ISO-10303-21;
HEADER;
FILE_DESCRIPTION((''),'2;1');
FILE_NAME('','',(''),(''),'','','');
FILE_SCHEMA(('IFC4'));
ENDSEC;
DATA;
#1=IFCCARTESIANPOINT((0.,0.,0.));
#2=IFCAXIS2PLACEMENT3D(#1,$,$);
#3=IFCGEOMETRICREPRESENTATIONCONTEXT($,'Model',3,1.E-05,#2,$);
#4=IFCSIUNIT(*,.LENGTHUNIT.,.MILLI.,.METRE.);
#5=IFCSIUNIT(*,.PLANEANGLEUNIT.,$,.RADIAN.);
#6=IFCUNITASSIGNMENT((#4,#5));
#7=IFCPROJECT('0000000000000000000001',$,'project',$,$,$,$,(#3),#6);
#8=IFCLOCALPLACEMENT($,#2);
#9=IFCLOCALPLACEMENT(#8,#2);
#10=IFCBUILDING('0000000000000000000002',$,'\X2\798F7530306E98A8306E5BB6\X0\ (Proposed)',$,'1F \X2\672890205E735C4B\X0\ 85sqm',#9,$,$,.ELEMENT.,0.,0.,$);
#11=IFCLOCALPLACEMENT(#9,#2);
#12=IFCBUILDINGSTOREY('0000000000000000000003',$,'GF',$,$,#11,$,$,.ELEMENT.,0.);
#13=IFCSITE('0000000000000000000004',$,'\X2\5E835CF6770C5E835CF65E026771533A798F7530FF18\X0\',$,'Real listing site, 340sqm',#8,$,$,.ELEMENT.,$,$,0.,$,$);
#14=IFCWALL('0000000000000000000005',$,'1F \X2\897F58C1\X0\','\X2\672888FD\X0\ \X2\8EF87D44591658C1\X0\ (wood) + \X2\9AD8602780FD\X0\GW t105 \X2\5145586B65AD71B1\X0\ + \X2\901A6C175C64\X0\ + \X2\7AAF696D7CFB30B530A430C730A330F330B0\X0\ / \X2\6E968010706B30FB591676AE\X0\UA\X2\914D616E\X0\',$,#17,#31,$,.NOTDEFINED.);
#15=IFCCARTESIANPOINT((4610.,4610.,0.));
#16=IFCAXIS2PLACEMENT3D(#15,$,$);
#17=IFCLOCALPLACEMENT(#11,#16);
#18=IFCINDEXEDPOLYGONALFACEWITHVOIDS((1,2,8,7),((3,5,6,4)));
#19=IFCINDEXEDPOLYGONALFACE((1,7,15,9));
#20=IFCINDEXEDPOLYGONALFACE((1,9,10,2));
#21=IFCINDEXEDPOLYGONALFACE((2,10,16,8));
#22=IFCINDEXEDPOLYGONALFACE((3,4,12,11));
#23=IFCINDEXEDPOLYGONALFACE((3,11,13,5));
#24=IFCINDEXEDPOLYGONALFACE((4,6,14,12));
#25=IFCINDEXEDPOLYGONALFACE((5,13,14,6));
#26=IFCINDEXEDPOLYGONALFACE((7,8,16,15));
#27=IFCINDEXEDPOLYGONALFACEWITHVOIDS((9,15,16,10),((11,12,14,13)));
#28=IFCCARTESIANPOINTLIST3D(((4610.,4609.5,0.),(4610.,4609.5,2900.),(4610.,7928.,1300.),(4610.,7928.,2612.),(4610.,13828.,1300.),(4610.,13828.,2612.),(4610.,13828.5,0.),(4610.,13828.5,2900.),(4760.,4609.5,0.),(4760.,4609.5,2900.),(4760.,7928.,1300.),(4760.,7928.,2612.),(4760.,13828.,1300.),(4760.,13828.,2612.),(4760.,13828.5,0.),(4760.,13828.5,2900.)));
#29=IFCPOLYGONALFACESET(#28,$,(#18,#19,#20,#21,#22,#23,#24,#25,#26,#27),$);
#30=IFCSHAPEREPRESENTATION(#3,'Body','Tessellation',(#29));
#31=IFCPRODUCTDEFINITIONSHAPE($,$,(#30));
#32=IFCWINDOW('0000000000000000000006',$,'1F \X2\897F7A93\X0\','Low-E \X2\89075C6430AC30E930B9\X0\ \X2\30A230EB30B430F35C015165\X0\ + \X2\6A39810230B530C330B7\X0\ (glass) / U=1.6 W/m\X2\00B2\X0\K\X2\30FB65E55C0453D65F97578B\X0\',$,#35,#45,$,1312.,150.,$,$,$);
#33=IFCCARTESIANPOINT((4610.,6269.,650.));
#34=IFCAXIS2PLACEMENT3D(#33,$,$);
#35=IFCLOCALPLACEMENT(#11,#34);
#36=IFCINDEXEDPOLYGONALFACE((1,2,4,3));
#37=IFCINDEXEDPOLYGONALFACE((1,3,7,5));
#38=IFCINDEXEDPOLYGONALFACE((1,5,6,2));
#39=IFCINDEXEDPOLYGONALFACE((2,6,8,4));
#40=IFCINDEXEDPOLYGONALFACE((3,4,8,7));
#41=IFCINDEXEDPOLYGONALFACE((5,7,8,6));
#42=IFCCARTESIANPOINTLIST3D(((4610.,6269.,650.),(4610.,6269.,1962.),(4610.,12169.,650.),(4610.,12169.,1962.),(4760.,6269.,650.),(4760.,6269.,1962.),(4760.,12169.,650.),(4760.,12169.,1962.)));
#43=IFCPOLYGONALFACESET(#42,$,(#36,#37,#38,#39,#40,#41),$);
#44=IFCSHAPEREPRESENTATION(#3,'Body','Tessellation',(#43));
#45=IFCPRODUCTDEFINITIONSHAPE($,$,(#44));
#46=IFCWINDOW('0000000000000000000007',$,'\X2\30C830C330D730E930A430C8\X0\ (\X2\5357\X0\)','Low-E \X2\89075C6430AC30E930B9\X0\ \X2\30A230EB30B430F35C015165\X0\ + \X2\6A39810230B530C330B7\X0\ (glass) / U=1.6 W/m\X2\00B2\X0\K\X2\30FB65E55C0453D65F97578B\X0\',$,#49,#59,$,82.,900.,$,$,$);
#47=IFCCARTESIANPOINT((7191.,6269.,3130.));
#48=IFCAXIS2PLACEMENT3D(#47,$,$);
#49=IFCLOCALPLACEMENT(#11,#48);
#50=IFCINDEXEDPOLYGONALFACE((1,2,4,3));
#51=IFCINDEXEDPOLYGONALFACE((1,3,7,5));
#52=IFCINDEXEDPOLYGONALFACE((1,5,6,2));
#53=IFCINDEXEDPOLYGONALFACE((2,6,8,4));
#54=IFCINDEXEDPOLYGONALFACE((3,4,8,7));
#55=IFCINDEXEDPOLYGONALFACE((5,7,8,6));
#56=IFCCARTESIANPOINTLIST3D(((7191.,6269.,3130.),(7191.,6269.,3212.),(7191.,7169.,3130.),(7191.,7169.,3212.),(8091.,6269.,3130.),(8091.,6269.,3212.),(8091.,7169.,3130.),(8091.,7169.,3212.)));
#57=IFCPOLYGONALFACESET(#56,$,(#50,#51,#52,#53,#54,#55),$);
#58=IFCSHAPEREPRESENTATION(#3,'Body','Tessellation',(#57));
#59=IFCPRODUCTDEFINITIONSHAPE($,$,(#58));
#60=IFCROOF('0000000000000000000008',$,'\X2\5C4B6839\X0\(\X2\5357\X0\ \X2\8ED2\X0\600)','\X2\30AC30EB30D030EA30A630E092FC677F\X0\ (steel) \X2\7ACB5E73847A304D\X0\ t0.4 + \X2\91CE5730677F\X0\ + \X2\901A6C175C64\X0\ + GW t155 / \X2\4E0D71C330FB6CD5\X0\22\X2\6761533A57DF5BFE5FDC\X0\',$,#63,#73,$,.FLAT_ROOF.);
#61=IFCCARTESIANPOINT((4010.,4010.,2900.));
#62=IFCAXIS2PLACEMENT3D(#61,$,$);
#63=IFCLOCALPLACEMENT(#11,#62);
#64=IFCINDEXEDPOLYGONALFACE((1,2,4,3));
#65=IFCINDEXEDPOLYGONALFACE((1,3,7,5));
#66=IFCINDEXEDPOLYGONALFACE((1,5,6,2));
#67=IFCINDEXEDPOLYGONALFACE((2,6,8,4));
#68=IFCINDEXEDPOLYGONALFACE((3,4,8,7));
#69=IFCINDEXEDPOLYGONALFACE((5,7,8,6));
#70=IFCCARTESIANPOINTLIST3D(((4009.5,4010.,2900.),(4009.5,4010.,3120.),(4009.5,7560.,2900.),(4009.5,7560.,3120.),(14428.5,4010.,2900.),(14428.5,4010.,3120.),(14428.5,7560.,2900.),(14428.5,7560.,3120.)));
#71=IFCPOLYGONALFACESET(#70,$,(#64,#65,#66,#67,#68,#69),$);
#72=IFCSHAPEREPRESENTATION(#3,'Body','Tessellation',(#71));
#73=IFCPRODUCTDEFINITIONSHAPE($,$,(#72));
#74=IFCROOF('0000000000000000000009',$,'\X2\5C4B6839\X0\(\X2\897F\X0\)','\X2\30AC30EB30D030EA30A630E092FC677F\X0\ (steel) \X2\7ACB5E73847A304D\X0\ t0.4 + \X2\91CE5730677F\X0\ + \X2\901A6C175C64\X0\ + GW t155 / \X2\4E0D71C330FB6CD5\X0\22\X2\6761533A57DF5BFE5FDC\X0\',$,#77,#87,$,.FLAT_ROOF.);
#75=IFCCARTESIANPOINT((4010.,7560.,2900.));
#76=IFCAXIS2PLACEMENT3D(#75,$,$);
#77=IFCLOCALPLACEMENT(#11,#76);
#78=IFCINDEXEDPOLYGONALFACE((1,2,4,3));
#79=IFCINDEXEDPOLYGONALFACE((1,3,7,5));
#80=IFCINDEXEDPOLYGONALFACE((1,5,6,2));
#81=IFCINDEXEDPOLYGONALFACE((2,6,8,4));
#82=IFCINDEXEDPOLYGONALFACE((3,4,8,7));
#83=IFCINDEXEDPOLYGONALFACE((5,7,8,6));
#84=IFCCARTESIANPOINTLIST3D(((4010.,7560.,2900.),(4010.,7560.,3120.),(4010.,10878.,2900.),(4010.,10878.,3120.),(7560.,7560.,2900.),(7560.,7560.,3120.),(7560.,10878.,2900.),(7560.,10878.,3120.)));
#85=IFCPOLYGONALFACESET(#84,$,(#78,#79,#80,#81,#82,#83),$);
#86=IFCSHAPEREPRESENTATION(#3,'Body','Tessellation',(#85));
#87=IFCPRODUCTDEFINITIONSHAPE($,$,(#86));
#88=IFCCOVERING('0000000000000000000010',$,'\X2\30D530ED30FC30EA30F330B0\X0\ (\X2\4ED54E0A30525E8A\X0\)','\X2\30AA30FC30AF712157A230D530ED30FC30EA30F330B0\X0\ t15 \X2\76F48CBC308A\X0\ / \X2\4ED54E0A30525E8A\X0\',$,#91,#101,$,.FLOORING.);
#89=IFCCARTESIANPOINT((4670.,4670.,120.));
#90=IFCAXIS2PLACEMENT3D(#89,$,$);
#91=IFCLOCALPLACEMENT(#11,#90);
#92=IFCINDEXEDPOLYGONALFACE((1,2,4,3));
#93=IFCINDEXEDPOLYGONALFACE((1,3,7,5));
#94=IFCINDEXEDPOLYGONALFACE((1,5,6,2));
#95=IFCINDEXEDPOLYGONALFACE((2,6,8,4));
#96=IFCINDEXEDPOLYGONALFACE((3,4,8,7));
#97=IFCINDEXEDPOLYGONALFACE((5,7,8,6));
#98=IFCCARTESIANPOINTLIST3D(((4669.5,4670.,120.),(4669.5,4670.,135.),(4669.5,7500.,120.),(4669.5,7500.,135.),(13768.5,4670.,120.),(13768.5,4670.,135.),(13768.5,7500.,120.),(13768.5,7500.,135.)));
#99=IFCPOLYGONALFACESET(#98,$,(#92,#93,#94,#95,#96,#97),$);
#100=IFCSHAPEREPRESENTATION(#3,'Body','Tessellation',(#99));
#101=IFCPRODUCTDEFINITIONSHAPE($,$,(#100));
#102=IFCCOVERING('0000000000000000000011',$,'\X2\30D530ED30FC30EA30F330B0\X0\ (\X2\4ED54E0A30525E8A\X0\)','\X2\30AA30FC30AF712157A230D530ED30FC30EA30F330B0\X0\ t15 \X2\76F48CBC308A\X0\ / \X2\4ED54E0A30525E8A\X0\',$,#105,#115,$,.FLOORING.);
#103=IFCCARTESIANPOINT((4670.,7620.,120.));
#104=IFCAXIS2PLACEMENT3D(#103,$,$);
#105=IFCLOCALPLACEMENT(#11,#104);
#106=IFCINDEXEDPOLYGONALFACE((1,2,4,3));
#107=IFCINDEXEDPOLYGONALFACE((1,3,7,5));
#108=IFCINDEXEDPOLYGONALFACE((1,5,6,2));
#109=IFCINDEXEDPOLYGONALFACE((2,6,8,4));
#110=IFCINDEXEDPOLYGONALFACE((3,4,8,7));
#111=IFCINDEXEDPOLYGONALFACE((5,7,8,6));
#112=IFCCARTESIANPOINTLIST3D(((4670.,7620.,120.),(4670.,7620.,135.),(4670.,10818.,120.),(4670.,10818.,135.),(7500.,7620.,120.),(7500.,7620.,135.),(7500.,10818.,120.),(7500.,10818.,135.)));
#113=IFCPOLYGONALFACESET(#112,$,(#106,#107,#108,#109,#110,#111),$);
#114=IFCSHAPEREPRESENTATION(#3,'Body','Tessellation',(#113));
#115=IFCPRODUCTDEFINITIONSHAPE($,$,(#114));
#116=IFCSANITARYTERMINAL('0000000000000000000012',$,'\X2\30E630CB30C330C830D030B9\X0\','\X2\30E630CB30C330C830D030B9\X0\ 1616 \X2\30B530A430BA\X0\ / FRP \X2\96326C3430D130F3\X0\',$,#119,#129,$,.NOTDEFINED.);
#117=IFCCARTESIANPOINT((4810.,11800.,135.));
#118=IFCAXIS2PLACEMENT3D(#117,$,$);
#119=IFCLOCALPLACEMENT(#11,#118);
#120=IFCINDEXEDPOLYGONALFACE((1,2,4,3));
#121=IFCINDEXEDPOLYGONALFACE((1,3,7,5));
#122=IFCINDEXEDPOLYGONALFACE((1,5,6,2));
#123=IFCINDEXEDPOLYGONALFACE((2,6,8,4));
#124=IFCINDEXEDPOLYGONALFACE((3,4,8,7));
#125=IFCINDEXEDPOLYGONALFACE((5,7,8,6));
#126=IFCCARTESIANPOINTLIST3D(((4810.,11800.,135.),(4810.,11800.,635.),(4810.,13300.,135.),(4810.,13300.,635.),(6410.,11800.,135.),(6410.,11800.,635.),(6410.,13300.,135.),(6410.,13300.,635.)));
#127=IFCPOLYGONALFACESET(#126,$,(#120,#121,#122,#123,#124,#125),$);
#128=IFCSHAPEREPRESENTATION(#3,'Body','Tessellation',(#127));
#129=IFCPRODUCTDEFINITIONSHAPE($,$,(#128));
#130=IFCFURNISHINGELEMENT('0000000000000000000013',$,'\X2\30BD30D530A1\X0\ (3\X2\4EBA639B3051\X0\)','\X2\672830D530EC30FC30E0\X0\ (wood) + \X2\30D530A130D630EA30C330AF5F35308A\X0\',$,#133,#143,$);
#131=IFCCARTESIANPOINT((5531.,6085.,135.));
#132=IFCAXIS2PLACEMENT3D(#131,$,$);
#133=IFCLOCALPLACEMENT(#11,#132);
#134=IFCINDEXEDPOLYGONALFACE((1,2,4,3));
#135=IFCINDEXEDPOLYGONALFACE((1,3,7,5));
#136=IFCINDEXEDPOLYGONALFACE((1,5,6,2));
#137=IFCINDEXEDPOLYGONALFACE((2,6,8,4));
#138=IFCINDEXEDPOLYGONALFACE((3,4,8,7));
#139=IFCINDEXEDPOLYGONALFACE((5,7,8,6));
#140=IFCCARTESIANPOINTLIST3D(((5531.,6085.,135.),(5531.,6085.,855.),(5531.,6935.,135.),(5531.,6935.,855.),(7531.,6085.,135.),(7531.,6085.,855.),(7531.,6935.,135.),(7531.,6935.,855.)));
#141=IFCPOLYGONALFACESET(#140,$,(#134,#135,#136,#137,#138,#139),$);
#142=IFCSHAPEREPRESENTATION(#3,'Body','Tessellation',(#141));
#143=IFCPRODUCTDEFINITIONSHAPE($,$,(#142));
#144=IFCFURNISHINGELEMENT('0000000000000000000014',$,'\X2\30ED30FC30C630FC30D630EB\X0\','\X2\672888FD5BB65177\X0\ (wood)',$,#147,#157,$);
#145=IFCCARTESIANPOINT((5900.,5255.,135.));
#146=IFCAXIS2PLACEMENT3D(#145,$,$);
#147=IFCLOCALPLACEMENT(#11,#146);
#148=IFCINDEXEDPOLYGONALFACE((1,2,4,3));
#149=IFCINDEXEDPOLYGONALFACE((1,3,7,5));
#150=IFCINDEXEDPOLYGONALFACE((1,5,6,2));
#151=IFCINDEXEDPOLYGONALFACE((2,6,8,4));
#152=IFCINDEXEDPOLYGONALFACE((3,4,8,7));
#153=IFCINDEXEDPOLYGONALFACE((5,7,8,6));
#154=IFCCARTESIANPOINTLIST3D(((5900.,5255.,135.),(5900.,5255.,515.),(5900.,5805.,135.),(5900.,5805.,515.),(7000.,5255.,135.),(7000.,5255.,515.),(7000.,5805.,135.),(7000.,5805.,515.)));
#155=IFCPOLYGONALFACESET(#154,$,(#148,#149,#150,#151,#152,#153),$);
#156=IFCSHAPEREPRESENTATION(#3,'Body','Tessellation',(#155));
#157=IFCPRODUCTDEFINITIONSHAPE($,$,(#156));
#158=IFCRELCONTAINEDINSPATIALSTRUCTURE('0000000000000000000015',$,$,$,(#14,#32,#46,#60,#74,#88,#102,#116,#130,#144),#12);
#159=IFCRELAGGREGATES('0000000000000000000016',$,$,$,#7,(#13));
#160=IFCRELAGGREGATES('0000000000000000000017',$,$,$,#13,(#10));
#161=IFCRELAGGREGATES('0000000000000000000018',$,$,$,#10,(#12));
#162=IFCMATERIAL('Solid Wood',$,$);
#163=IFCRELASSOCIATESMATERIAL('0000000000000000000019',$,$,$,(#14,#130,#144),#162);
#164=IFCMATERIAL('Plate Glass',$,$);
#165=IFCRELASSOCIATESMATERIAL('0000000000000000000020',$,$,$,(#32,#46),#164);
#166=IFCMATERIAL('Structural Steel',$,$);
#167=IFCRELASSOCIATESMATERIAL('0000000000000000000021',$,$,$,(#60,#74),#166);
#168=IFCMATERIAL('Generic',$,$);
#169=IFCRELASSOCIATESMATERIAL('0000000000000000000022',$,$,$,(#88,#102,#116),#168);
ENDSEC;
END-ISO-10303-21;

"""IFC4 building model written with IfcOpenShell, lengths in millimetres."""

from ifc_helpers import new_model, si_unit, frame, frame_2d, origin, place, context, project, spatial, rectangle, extrude, material, element, fill, save


model = new_model("IFC4")

# Units and contexts
model_context = context("Model", 3, precision=1e-05, world=origin())
ifc_project = project(units=[si_unit("LENGTHUNIT", "METRE", prefix="MILLI"), si_unit("PLANEANGLEUNIT", "RADIAN")], contexts=[model_context])

# Site, building, storey
site_placement = place(None, origin())
site = spatial("IfcSite", under=ifc_project, at=site_placement, Name="広島県広島市東区福田８", ObjectType="Real listing site, 340sqm", CompositionType="ELEMENT", RefElevation=0.0)
building_placement = place(site_placement, origin())
building = spatial("IfcBuilding", under=site, at=building_placement, Name="福田の風の家 (Proposed)", ObjectType="1F 木造平屋 85sqm", CompositionType="ELEMENT", ElevationOfRefHeight=0.0, ElevationOfTerrain=0.0)
storey_placement = place(building_placement, origin())
storey = spatial("IfcBuildingStorey", under=building, at=storey_placement, Name="GF", CompositionType="ELEMENT", Elevation=0.0)

# Shared definitions
ifc_material_1 = material(Name="Solid Wood")

# Shared definitions
ifc_material_2 = material(Name="Plate Glass")

# Wall, opening, window
wall_1_placement = place(storey_placement, frame((4610.0, 4610.0, 0.0)))
wall_1 = element("IfcWall", 1, at=wall_1_placement, inside=storey, material=ifc_material_1, Name="1F 西壁", Description="木製 軸組外壁 (wood) + 高性能GW t105 充填断熱 + 通気層 + 窯業系サイディング / 準耐火・外皮UA配慮", PredefinedType="NOTDEFINED", context=model_context, shape_type="SweptSolid", body=[
    extrude(rectangle(XDim=150.0, YDim=9219.0, at=frame_2d((75.0, 4609.0))), frame((4610.0, 4610.0, 0.0)), (0.0, 0.0, 1.0), 2900.0),
])
opening_1_placement = place(storey_placement, frame((4610.0, 6269.0, 650.0)))
opening_1 = element("IfcOpeningElement", 2, at=opening_1_placement, cuts=wall_1, PredefinedType="NOTDEFINED", context=model_context, shape_type="SweptSolid", body=[
    extrude(rectangle(XDim=150.0, YDim=5900.0, at=frame_2d((75.0, 2950.0))), frame((4610.0, 6269.0, 650.0)), (0.0, 0.0, 1.0), 1312.0),
])
window_1_placement = place(storey_placement, frame((4610.0, 6269.0, 650.0)))
window_1 = element("IfcWindow", 3, at=window_1_placement, inside=storey, material=ifc_material_2, Name="1F 西窓", Description="Low-E 複層ガラス アルゴン封入 + 樹脂サッシ (glass) / U=1.6 W/m²K・日射取得型", OverallHeight=1312.0, OverallWidth=150.0, context=model_context, shape_type="SweptSolid", body=[
    extrude(rectangle(XDim=150.0, YDim=5900.0, at=frame_2d((75.0, 2950.0))), frame((4610.0, 6269.0, 650.0)), (0.0, 0.0, 1.0), 1312.0),
])
fill(opening_1, window_1)

# Window
window_2_placement = place(storey_placement, frame((7191.0, 6269.0, 3130.0)))
element("IfcWindow", 4, at=window_2_placement, inside=storey, material=ifc_material_2, Name="トップライト (南)", Description="Low-E 複層ガラス アルゴン封入 + 樹脂サッシ (glass) / U=1.6 W/m²K・日射取得型", OverallHeight=82.0, OverallWidth=900.0, context=model_context, shape_type="SweptSolid", body=[
    extrude(rectangle(XDim=900.0, YDim=900.0, at=frame_2d((450.0, 450.0))), frame((7191.0, 6269.0, 3130.0)), (0.0, 0.0, 1.0), 82.0),
])

# Roofs
ifc_material_3 = material(Name="Structural Steel")
roof_1_placement = place(storey_placement, frame((4010.0, 4010.0, 2900.0)))
element("IfcRoof", 5, at=roof_1_placement, inside=storey, material=ifc_material_3, Name="屋根(南 軒600)", Description="ガルバリウム鋼板 (steel) 立平葺き t0.4 + 野地板 + 通気層 + GW t155 / 不燃・法22条区域対応", PredefinedType="FLAT_ROOF", context=model_context, shape_type="SweptSolid", body=[
    extrude(rectangle(XDim=10419.0, YDim=3550.0, at=frame_2d((5209.0, 1775.0))), frame((4010.0, 4010.0, 2900.0)), (0.0, 0.0, 1.0), 220.0),
])
roof_2_placement = place(storey_placement, frame((4010.0, 7560.0, 2900.0)))
element("IfcRoof", 6, at=roof_2_placement, inside=storey, material=ifc_material_3, Name="屋根(西)", Description="ガルバリウム鋼板 (steel) 立平葺き t0.4 + 野地板 + 通気層 + GW t155 / 不燃・法22条区域対応", PredefinedType="FLAT_ROOF", context=model_context, shape_type="SweptSolid", body=[
    extrude(rectangle(XDim=3550.0, YDim=3318.0, at=frame_2d((1775.0, 1659.0))), frame((4010.0, 7560.0, 2900.0)), (0.0, 0.0, 1.0), 220.0),
])

# Coverings
ifc_material_4 = material(Name="Generic")
covering_1_placement = place(storey_placement, frame((4670.0, 4670.0, 120.0)))
element("IfcCovering", 7, at=covering_1_placement, inside=storey, material=ifc_material_4, Name="フローリング (仕上げ床)", Description="オーク無垢フローリング t15 直貼り / 仕上げ床", PredefinedType="FLOORING", context=model_context, shape_type="SweptSolid", body=[
    extrude(rectangle(XDim=9099.0, YDim=2830.0, at=frame_2d((4549.0, 1415.0))), frame((4670.0, 4670.0, 120.0)), (0.0, 0.0, 1.0), 15.0),
])
covering_2_placement = place(storey_placement, frame((4670.0, 7620.0, 120.0)))
element("IfcCovering", 8, at=covering_2_placement, inside=storey, material=ifc_material_4, Name="フローリング (仕上げ床)", Description="オーク無垢フローリング t15 直貼り / 仕上げ床", PredefinedType="FLOORING", context=model_context, shape_type="SweptSolid", body=[
    extrude(rectangle(XDim=2830.0, YDim=3198.0, at=frame_2d((1415.0, 1599.0))), frame((4670.0, 7620.0, 120.0)), (0.0, 0.0, 1.0), 15.0),
])

# Sanitary terminal
sanitary_terminal_placement = place(storey_placement, frame((4810.0, 11800.0, 135.0)))
element("IfcSanitaryTerminal", 9, at=sanitary_terminal_placement, inside=storey, material=ifc_material_4, Name="ユニットバス", Description="ユニットバス 1616 サイズ / FRP 防水パン", PredefinedType="NOTDEFINED", context=model_context, shape_type="SweptSolid", body=[
    extrude(rectangle(XDim=1600.0, YDim=1500.0, at=frame_2d((800.0, 750.0))), frame((4810.0, 11800.0, 135.0)), (0.0, 0.0, 1.0), 500.0),
])

# Furnishing elements
furnishing_1_placement = place(storey_placement, frame((5531.0, 6085.0, 135.0)))
element("IfcFurnishingElement", 10, at=furnishing_1_placement, inside=storey, material=ifc_material_1, Name="ソファ (3人掛け)", Description="木フレーム (wood) + ファブリック張り", context=model_context, shape_type="SweptSolid", body=[
    extrude(rectangle(XDim=2000.0, YDim=850.0, at=frame_2d((1000.0, 425.0))), frame((5531.0, 6085.0, 135.0)), (0.0, 0.0, 1.0), 720.0),
])
furnishing_2_placement = place(storey_placement, frame((5900.0, 5255.0, 135.0)))
element("IfcFurnishingElement", 11, at=furnishing_2_placement, inside=storey, material=ifc_material_1, Name="ローテーブル", Description="木製家具 (wood)", context=model_context, shape_type="SweptSolid", body=[
    extrude(rectangle(XDim=1100.0, YDim=550.0, at=frame_2d((550.0, 275.0))), frame((5900.0, 5255.0, 135.0)), (0.0, 0.0, 1.0), 380.0),
])

save(model, "model.ifc")
